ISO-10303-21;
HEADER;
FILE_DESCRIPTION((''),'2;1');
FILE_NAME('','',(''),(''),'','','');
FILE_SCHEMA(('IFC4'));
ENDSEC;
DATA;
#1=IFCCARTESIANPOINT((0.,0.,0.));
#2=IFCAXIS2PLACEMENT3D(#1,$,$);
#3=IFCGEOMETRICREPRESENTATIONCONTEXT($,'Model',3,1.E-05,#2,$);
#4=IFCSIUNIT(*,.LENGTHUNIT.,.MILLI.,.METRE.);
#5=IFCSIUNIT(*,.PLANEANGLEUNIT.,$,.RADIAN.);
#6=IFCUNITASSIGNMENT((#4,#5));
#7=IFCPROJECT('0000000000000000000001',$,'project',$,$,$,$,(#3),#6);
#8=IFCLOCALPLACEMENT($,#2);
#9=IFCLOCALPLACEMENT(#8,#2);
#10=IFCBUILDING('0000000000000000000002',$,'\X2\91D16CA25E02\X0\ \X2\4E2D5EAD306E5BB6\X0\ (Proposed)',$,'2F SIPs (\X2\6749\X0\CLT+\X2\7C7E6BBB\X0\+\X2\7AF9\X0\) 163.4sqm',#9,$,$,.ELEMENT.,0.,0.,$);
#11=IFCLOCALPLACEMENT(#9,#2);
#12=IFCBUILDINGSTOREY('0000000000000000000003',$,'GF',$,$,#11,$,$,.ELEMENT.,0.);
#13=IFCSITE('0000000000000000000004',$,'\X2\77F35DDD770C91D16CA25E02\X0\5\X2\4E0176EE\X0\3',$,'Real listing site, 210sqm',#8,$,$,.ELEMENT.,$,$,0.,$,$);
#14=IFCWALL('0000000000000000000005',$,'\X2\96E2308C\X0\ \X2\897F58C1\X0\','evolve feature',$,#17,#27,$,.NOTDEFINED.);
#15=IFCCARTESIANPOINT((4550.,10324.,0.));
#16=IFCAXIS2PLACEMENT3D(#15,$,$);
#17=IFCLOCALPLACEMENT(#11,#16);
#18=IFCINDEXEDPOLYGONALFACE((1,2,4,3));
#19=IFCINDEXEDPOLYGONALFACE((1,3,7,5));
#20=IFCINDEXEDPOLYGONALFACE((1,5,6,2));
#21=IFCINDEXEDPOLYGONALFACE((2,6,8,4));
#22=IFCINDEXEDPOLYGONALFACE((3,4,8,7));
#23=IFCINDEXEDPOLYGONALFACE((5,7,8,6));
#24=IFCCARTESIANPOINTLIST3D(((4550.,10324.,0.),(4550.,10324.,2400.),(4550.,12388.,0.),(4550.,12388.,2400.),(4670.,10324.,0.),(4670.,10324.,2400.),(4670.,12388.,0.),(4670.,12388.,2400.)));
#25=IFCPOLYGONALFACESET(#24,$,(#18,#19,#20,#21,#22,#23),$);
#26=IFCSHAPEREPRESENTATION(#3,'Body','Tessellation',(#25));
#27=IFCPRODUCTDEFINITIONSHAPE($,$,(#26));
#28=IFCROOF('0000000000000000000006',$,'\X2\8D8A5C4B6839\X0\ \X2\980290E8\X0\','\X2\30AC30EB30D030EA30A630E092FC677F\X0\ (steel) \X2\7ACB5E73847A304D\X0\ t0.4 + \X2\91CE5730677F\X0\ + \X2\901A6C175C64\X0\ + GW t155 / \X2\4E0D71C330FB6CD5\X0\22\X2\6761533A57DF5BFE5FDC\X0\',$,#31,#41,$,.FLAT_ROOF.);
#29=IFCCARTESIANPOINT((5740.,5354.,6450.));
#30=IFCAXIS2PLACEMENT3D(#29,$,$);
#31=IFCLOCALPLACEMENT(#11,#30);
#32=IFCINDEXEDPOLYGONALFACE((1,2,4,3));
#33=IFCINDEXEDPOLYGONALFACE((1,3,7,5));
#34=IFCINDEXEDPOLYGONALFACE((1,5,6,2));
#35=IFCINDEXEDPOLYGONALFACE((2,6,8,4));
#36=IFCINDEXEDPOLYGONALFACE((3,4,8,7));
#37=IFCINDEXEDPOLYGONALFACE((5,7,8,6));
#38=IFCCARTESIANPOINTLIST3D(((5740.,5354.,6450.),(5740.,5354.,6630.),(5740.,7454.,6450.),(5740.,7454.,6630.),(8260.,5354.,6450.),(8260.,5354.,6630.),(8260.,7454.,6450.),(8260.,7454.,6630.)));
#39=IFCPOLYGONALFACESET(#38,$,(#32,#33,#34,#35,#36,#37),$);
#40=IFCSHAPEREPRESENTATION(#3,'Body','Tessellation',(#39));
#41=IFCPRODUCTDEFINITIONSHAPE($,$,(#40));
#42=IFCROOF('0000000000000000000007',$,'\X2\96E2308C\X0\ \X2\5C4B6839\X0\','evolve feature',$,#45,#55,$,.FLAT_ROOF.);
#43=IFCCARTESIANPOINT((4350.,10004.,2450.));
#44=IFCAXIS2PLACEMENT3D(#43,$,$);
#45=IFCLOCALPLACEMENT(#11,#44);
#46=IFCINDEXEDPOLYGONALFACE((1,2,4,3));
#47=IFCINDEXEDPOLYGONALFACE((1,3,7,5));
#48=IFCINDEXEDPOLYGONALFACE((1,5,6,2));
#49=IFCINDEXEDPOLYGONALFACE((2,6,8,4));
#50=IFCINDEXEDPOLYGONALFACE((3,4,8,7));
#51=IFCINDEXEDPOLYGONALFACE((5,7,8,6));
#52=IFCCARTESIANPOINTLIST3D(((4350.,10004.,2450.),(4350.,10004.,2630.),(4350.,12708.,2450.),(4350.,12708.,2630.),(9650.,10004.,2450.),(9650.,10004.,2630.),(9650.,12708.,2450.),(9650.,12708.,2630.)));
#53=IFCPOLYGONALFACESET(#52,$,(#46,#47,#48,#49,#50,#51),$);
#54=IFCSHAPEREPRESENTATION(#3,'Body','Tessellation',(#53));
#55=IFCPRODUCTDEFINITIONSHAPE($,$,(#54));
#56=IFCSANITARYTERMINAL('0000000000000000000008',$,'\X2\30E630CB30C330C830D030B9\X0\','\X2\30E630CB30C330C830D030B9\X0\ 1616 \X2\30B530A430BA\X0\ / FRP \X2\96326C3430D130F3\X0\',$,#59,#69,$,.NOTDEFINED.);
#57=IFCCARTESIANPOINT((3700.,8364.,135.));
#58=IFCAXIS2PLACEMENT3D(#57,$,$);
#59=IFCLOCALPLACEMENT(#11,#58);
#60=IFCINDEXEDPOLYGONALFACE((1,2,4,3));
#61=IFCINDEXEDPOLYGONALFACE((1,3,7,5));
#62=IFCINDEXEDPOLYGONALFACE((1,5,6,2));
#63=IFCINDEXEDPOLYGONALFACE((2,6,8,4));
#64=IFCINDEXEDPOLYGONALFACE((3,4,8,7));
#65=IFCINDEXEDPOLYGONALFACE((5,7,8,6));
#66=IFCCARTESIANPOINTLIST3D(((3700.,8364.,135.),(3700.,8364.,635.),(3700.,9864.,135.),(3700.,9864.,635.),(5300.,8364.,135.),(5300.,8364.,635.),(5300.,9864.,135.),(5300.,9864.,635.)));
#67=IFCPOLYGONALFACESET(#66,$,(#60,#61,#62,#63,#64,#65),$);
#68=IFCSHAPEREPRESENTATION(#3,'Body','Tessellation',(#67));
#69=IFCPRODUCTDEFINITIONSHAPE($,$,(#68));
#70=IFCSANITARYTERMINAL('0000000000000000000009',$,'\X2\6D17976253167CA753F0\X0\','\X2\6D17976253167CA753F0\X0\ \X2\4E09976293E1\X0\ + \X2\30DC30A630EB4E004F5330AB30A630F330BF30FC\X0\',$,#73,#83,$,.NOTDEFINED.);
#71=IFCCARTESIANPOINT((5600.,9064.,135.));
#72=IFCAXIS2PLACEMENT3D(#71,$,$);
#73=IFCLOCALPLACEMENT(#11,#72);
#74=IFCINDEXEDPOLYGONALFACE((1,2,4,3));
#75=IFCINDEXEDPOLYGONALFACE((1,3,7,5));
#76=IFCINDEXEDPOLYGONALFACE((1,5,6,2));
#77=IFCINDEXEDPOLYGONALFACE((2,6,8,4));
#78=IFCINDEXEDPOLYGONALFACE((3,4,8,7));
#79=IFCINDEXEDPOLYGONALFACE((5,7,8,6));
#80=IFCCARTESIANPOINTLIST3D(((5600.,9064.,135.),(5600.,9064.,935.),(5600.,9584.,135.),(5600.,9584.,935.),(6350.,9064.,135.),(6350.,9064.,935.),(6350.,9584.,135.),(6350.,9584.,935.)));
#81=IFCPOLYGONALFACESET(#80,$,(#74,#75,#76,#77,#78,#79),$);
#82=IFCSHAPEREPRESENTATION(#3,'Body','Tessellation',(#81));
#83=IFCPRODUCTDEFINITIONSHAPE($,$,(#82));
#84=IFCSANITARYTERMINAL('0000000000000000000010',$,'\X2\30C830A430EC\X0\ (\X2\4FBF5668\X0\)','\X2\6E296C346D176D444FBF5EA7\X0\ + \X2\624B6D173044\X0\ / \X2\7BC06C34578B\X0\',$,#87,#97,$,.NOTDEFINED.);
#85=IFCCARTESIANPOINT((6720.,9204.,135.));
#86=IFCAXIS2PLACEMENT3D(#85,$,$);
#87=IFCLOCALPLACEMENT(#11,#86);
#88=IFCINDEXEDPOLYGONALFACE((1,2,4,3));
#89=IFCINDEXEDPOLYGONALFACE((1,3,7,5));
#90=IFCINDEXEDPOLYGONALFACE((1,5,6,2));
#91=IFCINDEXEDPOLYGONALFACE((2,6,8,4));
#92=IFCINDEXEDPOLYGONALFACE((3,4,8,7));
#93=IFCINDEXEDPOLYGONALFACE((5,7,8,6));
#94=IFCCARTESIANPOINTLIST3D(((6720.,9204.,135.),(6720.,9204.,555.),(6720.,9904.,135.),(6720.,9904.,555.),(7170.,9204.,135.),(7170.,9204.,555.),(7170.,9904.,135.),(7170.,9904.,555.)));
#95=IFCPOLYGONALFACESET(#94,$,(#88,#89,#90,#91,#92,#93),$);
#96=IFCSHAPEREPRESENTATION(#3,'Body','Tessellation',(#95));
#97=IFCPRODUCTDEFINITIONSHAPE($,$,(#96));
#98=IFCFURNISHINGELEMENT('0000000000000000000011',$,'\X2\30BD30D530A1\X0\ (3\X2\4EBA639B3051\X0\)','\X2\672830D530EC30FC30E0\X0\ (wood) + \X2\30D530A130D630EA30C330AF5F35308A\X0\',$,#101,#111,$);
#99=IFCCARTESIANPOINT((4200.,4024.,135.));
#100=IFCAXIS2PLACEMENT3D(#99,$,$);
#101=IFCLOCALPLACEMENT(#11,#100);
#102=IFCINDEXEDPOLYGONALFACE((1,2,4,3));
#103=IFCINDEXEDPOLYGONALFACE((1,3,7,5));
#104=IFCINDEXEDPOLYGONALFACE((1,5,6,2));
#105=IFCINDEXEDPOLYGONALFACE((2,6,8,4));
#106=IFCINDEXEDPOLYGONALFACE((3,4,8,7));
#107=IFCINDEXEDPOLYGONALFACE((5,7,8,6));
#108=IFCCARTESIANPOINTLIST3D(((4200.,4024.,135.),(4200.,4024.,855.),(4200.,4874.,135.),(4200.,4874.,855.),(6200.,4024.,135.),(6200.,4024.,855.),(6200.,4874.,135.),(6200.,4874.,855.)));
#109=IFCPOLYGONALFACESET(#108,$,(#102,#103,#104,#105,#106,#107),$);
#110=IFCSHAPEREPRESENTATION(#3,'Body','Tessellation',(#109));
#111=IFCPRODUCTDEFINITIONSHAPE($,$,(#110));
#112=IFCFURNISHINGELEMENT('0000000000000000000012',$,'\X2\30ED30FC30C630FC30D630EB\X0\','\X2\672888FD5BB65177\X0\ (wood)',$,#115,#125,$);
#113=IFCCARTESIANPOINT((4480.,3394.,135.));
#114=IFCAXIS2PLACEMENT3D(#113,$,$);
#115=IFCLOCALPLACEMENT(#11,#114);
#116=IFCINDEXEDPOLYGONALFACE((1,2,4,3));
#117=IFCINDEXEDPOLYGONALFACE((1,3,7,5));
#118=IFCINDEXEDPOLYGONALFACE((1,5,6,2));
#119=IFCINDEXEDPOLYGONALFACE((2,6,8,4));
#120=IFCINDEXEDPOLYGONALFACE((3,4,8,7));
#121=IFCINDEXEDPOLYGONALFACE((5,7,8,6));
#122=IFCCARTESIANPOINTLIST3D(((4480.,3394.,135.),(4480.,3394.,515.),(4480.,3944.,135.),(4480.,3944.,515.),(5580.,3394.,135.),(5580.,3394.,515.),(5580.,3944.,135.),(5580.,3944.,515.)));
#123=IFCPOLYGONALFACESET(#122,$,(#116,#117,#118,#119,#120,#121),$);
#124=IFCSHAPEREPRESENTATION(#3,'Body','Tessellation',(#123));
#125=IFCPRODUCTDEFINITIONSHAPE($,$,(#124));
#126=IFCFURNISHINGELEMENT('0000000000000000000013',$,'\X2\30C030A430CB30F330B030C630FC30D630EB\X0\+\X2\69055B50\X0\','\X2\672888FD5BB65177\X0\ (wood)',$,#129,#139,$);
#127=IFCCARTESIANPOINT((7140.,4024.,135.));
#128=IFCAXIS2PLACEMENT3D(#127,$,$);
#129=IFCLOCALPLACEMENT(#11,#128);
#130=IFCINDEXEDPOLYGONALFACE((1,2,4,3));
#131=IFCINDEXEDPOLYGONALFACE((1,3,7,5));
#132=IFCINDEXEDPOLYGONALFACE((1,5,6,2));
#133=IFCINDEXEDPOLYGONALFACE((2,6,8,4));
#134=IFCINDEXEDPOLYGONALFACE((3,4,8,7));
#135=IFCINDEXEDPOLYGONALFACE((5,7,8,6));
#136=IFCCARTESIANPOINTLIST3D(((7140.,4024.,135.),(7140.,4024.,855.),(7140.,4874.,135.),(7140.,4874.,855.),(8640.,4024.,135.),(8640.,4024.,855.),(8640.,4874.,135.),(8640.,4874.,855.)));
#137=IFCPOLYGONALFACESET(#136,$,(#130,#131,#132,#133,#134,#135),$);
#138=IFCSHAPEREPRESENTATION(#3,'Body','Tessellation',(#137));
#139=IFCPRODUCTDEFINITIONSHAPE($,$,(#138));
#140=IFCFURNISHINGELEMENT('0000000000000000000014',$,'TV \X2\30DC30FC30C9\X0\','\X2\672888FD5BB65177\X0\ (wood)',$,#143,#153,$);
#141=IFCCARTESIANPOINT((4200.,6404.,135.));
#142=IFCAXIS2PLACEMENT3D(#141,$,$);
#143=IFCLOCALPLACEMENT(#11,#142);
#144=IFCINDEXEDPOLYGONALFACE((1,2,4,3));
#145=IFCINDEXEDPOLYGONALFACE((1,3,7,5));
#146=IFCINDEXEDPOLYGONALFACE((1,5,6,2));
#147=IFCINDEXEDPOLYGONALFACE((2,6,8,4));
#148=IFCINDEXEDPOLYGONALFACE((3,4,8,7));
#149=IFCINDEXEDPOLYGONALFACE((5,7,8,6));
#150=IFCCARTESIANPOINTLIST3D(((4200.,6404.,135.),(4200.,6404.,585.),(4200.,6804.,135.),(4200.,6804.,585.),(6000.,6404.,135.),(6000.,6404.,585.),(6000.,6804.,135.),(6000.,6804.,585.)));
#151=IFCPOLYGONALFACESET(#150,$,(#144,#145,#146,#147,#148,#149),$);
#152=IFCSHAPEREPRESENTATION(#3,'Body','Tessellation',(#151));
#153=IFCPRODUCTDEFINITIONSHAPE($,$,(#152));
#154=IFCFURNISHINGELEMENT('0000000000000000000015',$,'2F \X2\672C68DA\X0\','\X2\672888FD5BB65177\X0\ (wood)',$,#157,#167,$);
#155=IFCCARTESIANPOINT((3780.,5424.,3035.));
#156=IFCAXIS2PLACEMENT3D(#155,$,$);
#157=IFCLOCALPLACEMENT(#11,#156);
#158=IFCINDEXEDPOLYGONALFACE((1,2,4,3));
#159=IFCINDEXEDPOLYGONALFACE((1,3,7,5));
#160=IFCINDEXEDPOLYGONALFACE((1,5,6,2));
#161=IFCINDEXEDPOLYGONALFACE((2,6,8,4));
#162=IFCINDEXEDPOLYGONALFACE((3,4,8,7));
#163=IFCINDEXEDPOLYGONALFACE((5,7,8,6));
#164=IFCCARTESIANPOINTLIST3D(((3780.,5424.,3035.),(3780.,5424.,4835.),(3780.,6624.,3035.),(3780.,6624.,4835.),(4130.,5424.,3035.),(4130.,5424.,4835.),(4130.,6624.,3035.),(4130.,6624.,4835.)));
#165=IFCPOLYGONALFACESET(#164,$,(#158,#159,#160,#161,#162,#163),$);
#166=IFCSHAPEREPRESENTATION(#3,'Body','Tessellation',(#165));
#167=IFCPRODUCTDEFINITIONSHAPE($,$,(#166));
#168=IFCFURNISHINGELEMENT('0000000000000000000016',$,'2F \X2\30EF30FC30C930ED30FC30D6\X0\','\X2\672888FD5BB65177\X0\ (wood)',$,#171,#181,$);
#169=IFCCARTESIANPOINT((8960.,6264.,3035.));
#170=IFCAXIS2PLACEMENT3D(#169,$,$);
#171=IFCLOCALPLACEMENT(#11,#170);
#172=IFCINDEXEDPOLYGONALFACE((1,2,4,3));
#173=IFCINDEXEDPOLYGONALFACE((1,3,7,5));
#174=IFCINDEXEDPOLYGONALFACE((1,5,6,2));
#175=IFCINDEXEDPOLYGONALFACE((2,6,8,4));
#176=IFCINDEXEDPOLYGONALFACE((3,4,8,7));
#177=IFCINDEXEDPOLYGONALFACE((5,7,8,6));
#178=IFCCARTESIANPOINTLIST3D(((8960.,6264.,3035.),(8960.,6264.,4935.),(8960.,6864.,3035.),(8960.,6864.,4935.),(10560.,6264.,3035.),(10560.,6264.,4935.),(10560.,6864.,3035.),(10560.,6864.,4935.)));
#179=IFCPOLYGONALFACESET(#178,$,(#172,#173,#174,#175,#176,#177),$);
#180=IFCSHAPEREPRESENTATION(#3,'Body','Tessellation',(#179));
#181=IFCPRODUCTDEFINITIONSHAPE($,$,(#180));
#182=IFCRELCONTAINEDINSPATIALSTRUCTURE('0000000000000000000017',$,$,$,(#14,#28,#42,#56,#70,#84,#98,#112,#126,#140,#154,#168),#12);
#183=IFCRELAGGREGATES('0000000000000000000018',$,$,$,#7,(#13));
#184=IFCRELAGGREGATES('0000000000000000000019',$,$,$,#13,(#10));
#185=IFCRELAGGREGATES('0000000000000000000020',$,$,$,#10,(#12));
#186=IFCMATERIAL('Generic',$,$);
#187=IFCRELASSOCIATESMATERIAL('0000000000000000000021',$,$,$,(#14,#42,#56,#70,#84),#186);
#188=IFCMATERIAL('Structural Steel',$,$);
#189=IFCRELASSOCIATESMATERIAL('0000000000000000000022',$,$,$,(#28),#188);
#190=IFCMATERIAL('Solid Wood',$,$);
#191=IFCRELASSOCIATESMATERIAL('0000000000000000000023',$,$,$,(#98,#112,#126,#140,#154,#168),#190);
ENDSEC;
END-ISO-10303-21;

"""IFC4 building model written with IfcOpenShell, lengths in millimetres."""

from ifc_helpers import new_model, si_unit, frame, frame_2d, origin, place, context, project, spatial, rectangle, extrude, material, element, save


model = new_model("IFC4")

# Units and contexts
model_context = context("Model", 3, precision=1e-05, world=origin())
ifc_project = project(units=[si_unit("LENGTHUNIT", "METRE", prefix="MILLI"), si_unit("PLANEANGLEUNIT", "RADIAN")], contexts=[model_context])

# Site, building, storey
site_placement = place(None, origin())
site = spatial("IfcSite", under=ifc_project, at=site_placement, Name="石川県金沢市5丁目3", ObjectType="Real listing site, 210sqm", CompositionType="ELEMENT", RefElevation=0.0)
building_placement = place(site_placement, origin())
building = spatial("IfcBuilding", under=site, at=building_placement, Name="金沢市 中庭の家 (Proposed)", ObjectType="2F SIPs (杉CLT+籾殻+竹) 163.4sqm", CompositionType="ELEMENT", ElevationOfRefHeight=0.0, ElevationOfTerrain=0.0)
storey_placement = place(building_placement, origin())
storey = spatial("IfcBuildingStorey", under=building, at=storey_placement, Name="GF", CompositionType="ELEMENT", Elevation=0.0)

# Shared definitions
ifc_material_1 = material(Name="Generic")

# Shared definitions
ifc_material_2 = material(Name="Solid Wood")

# Wall
wall_1_placement = place(storey_placement, frame((4550.0, 10324.0, 0.0)))
element("IfcWall", 1, at=wall_1_placement, inside=storey, material=ifc_material_1, Name="離れ 西壁", Description="evolve feature", PredefinedType="NOTDEFINED", context=model_context, shape_type="SweptSolid", body=[
    extrude(rectangle(XDim=120.0, YDim=2064.0, at=frame_2d((60.0, 1032.0))), frame((4550.0, 10324.0, 0.0)), (0.0, 0.0, 1.0), 2400.0),
])

# Roofs
ifc_material_3 = material(Name="Structural Steel")
roof_1_placement = place(storey_placement, frame((5740.0, 5354.0, 6450.0)))
element("IfcRoof", 2, at=roof_1_placement, inside=storey, material=ifc_material_3, Name="越屋根 頂部", Description="ガルバリウム鋼板 (steel) 立平葺き t0.4 + 野地板 + 通気層 + GW t155 / 不燃・法22条区域対応", PredefinedType="FLAT_ROOF", context=model_context, shape_type="SweptSolid", body=[
    extrude(rectangle(XDim=2520.0, YDim=2100.0, at=frame_2d((1260.0, 1050.0))), frame((5740.0, 5354.0, 6450.0)), (0.0, 0.0, 1.0), 180.0),
])
roof_2_placement = place(storey_placement, frame((4350.0, 10004.0, 2450.0)))
element("IfcRoof", 3, at=roof_2_placement, inside=storey, material=ifc_material_1, Name="離れ 屋根", Description="evolve feature", PredefinedType="FLAT_ROOF", context=model_context, shape_type="SweptSolid", body=[
    extrude(rectangle(XDim=5300.0, YDim=2704.0, at=frame_2d((2650.0, 1352.0))), frame((4350.0, 10004.0, 2450.0)), (0.0, 0.0, 1.0), 180.0),
])

# Sanitary terminals
sanitary_terminal_1_placement = place(storey_placement, frame((3700.0, 8364.0, 135.0)))
element("IfcSanitaryTerminal", 4, at=sanitary_terminal_1_placement, inside=storey, material=ifc_material_1, Name="ユニットバス", Description="ユニットバス 1616 サイズ / FRP 防水パン", PredefinedType="NOTDEFINED", context=model_context, shape_type="SweptSolid", body=[
    extrude(rectangle(XDim=1600.0, YDim=1500.0, at=frame_2d((800.0, 750.0))), frame((3700.0, 8364.0, 135.0)), (0.0, 0.0, 1.0), 500.0),
])
sanitary_terminal_2_placement = place(storey_placement, frame((5600.0, 9064.0, 135.0)))
element("IfcSanitaryTerminal", 5, at=sanitary_terminal_2_placement, inside=storey, material=ifc_material_1, Name="洗面化粧台", Description="洗面化粧台 三面鏡 + ボウル一体カウンター", PredefinedType="NOTDEFINED", context=model_context, shape_type="SweptSolid", body=[
    extrude(rectangle(XDim=750.0, YDim=520.0, at=frame_2d((375.0, 260.0))), frame((5600.0, 9064.0, 135.0)), (0.0, 0.0, 1.0), 800.0),
])
sanitary_terminal_3_placement = place(storey_placement, frame((6720.0, 9204.0, 135.0)))
element("IfcSanitaryTerminal", 6, at=sanitary_terminal_3_placement, inside=storey, material=ifc_material_1, Name="トイレ (便器)", Description="温水洗浄便座 + 手洗い / 節水型", PredefinedType="NOTDEFINED", context=model_context, shape_type="SweptSolid", body=[
    extrude(rectangle(XDim=450.0, YDim=700.0, at=frame_2d((225.0, 350.0))), frame((6720.0, 9204.0, 135.0)), (0.0, 0.0, 1.0), 420.0),
])

# Furnishing elements
furnishing_1_placement = place(storey_placement, frame((4200.0, 4024.0, 135.0)))
element("IfcFurnishingElement", 7, at=furnishing_1_placement, inside=storey, material=ifc_material_2, Name="ソファ (3人掛け)", Description="木フレーム (wood) + ファブリック張り", context=model_context, shape_type="SweptSolid", body=[
    extrude(rectangle(XDim=2000.0, YDim=850.0, at=frame_2d((1000.0, 425.0))), frame((4200.0, 4024.0, 135.0)), (0.0, 0.0, 1.0), 720.0),
])
furnishing_2_placement = place(storey_placement, frame((4480.0, 3394.0, 135.0)))
element("IfcFurnishingElement", 8, at=furnishing_2_placement, inside=storey, material=ifc_material_2, Name="ローテーブル", Description="木製家具 (wood)", context=model_context, shape_type="SweptSolid", body=[
    extrude(rectangle(XDim=1100.0, YDim=550.0, at=frame_2d((550.0, 275.0))), frame((4480.0, 3394.0, 135.0)), (0.0, 0.0, 1.0), 380.0),
])
furnishing_3_placement = place(storey_placement, frame((7140.0, 4024.0, 135.0)))
element("IfcFurnishingElement", 9, at=furnishing_3_placement, inside=storey, material=ifc_material_2, Name="ダイニングテーブル+椅子", Description="木製家具 (wood)", context=model_context, shape_type="SweptSolid", body=[
    extrude(rectangle(XDim=1500.0, YDim=850.0, at=frame_2d((750.0, 425.0))), frame((7140.0, 4024.0, 135.0)), (0.0, 0.0, 1.0), 720.0),
])
furnishing_4_placement = place(storey_placement, frame((4200.0, 6404.0, 135.0)))
element("IfcFurnishingElement", 10, at=furnishing_4_placement, inside=storey, material=ifc_material_2, Name="TV ボード", Description="木製家具 (wood)", context=model_context, shape_type="SweptSolid", body=[
    extrude(rectangle(XDim=1800.0, YDim=400.0, at=frame_2d((900.0, 200.0))), frame((4200.0, 6404.0, 135.0)), (0.0, 0.0, 1.0), 450.0),
])
furnishing_5_placement = place(storey_placement, frame((3780.0, 5424.0, 3035.0)))
element("IfcFurnishingElement", 11, at=furnishing_5_placement, inside=storey, material=ifc_material_2, Name="2F 本棚", Description="木製家具 (wood)", context=model_context, shape_type="SweptSolid", body=[
    extrude(rectangle(XDim=350.0, YDim=1200.0, at=frame_2d((175.0, 600.0))), frame((3780.0, 5424.0, 3035.0)), (0.0, 0.0, 1.0), 1800.0),
])
furnishing_6_placement = place(storey_placement, frame((8960.0, 6264.0, 3035.0)))
element("IfcFurnishingElement", 12, at=furnishing_6_placement, inside=storey, material=ifc_material_2, Name="2F ワードローブ", Description="木製家具 (wood)", context=model_context, shape_type="SweptSolid", body=[
    extrude(rectangle(XDim=1600.0, YDim=600.0, at=frame_2d((800.0, 300.0))), frame((8960.0, 6264.0, 3035.0)), (0.0, 0.0, 1.0), 1900.0),
])

save(model, "model.ifc")
